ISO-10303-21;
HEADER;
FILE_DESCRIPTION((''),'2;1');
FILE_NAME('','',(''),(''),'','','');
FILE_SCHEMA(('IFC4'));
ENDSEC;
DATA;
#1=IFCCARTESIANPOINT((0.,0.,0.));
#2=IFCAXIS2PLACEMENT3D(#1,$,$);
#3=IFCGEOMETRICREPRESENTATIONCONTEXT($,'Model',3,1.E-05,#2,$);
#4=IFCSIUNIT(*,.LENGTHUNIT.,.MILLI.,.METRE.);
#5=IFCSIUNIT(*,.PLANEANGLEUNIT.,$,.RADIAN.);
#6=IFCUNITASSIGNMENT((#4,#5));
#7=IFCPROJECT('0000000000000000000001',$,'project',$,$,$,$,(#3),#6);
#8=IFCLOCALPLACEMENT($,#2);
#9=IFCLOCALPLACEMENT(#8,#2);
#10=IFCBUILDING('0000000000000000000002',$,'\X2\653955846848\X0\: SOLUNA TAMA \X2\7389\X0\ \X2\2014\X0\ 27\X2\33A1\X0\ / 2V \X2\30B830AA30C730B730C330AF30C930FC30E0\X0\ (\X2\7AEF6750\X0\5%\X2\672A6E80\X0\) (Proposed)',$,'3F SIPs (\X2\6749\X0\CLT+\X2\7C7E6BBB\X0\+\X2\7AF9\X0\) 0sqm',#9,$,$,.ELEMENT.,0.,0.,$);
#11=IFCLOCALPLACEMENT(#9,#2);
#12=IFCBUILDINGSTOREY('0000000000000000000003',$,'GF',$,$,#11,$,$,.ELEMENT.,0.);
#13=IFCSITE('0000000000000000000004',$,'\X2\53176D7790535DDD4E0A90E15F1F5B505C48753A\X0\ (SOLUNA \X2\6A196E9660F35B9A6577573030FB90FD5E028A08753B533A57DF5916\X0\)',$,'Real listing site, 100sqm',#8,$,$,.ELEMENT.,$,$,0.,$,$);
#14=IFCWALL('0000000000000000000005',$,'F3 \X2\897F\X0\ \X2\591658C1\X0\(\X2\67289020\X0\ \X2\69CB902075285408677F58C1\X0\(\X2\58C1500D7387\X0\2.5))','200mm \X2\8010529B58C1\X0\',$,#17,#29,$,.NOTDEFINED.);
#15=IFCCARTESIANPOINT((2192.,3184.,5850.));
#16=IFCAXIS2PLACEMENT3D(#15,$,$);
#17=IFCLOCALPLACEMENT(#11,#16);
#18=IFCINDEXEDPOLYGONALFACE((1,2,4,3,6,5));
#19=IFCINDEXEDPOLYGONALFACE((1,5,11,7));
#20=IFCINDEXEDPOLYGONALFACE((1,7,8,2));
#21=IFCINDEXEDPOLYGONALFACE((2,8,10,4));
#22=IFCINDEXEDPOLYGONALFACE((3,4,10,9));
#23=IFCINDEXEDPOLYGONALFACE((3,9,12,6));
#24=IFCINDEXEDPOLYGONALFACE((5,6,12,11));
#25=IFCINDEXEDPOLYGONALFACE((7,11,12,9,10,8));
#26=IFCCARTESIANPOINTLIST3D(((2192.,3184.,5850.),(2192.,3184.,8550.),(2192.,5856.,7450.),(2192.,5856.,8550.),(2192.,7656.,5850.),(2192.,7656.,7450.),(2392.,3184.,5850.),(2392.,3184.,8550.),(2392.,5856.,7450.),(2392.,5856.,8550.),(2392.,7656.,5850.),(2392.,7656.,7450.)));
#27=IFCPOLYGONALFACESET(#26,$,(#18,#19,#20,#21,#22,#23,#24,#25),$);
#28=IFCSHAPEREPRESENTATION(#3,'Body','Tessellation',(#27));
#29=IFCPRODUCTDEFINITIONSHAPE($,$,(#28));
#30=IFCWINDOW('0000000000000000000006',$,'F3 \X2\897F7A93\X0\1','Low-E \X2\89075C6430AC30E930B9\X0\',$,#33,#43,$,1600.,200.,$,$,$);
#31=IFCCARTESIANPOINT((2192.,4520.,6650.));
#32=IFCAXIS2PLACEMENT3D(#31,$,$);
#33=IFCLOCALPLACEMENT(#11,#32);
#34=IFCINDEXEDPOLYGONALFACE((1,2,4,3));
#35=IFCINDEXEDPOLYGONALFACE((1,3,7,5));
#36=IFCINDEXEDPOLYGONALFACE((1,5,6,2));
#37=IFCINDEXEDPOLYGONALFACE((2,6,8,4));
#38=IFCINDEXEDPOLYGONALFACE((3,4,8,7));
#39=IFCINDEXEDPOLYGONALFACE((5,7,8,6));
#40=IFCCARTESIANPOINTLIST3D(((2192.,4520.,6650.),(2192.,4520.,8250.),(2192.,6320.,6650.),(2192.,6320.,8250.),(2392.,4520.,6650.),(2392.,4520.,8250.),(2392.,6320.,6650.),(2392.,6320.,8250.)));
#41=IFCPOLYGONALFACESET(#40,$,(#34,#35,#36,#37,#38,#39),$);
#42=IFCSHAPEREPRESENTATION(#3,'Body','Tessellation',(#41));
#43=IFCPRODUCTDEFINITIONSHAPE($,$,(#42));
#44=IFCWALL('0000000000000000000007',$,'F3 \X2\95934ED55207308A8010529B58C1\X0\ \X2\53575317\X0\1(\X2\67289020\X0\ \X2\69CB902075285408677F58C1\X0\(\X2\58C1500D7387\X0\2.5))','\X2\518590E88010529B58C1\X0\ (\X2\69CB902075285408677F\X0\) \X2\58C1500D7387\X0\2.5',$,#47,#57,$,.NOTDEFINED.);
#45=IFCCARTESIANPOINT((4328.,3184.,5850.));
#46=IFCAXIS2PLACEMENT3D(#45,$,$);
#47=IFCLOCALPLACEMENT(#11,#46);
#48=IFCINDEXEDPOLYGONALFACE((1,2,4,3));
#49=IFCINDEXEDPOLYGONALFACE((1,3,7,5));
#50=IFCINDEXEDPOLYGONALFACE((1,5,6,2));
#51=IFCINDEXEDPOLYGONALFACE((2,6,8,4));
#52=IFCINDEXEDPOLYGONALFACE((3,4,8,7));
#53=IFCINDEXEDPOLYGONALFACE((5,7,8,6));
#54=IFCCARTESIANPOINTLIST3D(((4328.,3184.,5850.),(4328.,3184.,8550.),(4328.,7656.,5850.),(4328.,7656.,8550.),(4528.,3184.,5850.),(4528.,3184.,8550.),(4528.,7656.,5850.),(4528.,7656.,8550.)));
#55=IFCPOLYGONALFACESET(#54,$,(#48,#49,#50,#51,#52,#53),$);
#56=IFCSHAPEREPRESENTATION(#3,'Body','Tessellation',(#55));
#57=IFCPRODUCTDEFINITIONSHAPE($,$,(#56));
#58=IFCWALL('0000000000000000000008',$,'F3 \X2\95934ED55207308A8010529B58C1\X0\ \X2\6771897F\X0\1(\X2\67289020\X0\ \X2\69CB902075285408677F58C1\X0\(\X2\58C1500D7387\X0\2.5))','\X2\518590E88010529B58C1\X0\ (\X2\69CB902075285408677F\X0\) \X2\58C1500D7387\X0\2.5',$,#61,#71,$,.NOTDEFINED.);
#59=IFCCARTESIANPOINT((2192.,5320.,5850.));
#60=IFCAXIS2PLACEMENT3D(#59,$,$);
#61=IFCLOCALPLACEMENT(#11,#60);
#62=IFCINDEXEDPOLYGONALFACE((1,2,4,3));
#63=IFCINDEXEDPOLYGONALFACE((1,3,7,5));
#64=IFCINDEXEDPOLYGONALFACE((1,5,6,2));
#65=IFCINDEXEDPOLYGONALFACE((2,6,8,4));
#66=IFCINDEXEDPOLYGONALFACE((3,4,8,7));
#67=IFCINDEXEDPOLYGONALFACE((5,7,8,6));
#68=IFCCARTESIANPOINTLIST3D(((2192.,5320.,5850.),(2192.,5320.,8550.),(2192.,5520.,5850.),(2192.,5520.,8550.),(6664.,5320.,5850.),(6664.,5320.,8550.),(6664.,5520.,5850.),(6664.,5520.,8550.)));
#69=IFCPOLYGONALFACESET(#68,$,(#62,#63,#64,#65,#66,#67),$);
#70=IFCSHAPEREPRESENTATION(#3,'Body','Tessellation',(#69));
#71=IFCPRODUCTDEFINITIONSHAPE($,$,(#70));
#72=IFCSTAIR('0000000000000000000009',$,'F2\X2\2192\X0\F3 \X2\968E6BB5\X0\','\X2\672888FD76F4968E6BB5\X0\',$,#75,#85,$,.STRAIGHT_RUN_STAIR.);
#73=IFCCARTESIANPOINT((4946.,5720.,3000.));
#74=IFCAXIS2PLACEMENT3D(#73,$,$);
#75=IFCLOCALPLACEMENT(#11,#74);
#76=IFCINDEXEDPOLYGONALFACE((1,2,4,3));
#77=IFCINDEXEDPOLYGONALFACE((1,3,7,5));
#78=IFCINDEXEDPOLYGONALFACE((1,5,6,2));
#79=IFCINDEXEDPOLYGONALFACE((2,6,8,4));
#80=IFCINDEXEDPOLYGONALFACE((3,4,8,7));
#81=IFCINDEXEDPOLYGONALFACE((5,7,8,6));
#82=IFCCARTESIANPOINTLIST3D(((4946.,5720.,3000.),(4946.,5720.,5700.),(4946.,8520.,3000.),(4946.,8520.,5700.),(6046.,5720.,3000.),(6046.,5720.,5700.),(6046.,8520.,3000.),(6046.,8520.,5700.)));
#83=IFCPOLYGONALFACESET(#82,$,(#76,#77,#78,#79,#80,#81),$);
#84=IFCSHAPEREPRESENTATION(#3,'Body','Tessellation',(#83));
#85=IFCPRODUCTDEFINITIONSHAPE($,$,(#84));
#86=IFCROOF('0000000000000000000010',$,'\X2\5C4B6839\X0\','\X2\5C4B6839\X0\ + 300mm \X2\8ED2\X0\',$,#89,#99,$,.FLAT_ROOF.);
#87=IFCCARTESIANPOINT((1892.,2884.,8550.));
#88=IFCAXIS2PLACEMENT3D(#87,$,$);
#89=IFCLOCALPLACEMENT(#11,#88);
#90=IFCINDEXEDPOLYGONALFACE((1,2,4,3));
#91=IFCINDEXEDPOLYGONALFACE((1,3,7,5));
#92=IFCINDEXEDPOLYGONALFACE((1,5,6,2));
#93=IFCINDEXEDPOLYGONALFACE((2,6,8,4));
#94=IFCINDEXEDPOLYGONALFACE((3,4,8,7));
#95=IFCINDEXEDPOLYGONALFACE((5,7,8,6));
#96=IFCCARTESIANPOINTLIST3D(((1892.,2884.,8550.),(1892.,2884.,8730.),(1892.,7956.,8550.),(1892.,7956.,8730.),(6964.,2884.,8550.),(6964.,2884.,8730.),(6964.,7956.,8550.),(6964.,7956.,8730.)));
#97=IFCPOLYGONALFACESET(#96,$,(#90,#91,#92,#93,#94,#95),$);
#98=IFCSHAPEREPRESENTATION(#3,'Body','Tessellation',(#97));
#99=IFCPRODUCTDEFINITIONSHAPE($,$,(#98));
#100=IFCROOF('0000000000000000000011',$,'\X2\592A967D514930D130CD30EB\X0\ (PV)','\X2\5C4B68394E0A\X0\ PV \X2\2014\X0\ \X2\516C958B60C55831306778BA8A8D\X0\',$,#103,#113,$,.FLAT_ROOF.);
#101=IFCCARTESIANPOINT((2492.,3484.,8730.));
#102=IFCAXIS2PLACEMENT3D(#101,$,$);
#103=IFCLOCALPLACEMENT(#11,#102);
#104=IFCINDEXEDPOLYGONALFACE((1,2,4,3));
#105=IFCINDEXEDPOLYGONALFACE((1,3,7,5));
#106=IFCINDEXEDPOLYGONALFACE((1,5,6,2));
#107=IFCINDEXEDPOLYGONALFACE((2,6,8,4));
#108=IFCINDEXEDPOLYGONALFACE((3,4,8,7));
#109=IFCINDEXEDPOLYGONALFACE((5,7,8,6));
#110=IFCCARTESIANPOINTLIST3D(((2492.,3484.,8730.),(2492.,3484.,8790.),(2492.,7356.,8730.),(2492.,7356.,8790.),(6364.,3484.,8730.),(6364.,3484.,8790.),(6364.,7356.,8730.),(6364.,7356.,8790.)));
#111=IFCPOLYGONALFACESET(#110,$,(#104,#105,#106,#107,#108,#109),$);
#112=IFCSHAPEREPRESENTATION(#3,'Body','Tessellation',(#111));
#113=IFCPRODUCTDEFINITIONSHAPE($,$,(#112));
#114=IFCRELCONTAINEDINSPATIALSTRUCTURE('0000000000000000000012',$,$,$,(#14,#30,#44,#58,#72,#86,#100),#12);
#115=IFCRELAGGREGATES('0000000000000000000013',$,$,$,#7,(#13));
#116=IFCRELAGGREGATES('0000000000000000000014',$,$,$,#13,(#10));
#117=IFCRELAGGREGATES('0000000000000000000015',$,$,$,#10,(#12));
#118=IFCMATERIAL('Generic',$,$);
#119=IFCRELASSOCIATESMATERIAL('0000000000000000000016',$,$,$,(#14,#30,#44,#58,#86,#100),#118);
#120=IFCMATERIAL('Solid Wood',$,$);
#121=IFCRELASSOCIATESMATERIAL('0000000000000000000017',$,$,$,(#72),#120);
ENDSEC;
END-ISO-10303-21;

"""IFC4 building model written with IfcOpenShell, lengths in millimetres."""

from ifc_helpers import new_model, si_unit, frame, frame_2d, origin, place, context, project, spatial, rectangle, extrude, material, element, fill, save


model = new_model("IFC4")

# Units and contexts
model_context = context("Model", 3, precision=1e-05, world=origin())
ifc_project = project(units=[si_unit("LENGTHUNIT", "METRE", prefix="MILLI"), si_unit("PLANEANGLEUNIT", "RADIAN")], contexts=[model_context])

# Site, building, storey
site_placement = place(None, origin())
site = spatial("IfcSite", under=ifc_project, at=site_placement, Name="北海道川上郡弟子屈町 (SOLUNA 標準想定敷地・都市計画区域外)", ObjectType="Real listing site, 100sqm", CompositionType="ELEMENT", RefElevation=0.0)
building_placement = place(site_placement, origin())
building = spatial("IfcBuilding", under=site, at=building_placement, Name="改善案: SOLUNA TAMA 玉 — 27㎡ / 2V ジオデシックドーム (端材5%未満) (Proposed)", ObjectType="3F SIPs (杉CLT+籾殻+竹) 0sqm", CompositionType="ELEMENT", ElevationOfRefHeight=0.0, ElevationOfTerrain=0.0)
storey_placement = place(building_placement, origin())
storey = spatial("IfcBuildingStorey", under=building, at=storey_placement, Name="GF", CompositionType="ELEMENT", Elevation=0.0)

# Shared definitions
ifc_material_1 = material(Name="Generic")

# Wall, opening, window
wall_1_placement = place(storey_placement, frame((2192.0, 3184.0, 5850.0)))
wall_1 = element("IfcWall", 1, at=wall_1_placement, inside=storey, material=ifc_material_1, Name="F3 西 外壁(木造 構造用合板壁(壁倍率2.5))", Description="200mm 耐力壁", PredefinedType="NOTDEFINED", context=model_context, shape_type="SweptSolid", body=[
    extrude(rectangle(XDim=200.0, YDim=4472.0, at=frame_2d((100.0, 2236.0))), frame((2192.0, 3184.0, 5850.0)), (0.0, 0.0, 1.0), 2700.0),
])
opening_1_placement = place(storey_placement, frame((2192.0, 4520.0, 6650.0)))
opening_1 = element("IfcOpeningElement", 2, at=opening_1_placement, cuts=wall_1, PredefinedType="NOTDEFINED", context=model_context, shape_type="SweptSolid", body=[
    extrude(rectangle(XDim=200.0, YDim=1800.0, at=frame_2d((100.0, 900.0))), frame((2192.0, 4520.0, 6650.0)), (0.0, 0.0, 1.0), 1600.0),
])
window_1_placement = place(storey_placement, frame((2192.0, 4520.0, 6650.0)))
window_1 = element("IfcWindow", 3, at=window_1_placement, inside=storey, material=ifc_material_1, Name="F3 西窓1", Description="Low-E 複層ガラス", OverallHeight=1600.0, OverallWidth=200.0, context=model_context, shape_type="SweptSolid", body=[
    extrude(rectangle(XDim=200.0, YDim=1800.0, at=frame_2d((100.0, 900.0))), frame((2192.0, 4520.0, 6650.0)), (0.0, 0.0, 1.0), 1600.0),
])
fill(opening_1, window_1)

# Walls
wall_2_placement = place(storey_placement, frame((4328.0, 3184.0, 5850.0)))
element("IfcWall", 4, at=wall_2_placement, inside=storey, material=ifc_material_1, Name="F3 間仕切り耐力壁 南北1(木造 構造用合板壁(壁倍率2.5))", Description="内部耐力壁 (構造用合板) 壁倍率2.5", PredefinedType="NOTDEFINED", context=model_context, shape_type="SweptSolid", body=[
    extrude(rectangle(XDim=200.0, YDim=4472.0, at=frame_2d((100.0, 2236.0))), frame((4328.0, 3184.0, 5850.0)), (0.0, 0.0, 1.0), 2700.0),
])
wall_3_placement = place(storey_placement, frame((2192.0, 5320.0, 5850.0)))
element("IfcWall", 5, at=wall_3_placement, inside=storey, material=ifc_material_1, Name="F3 間仕切り耐力壁 東西1(木造 構造用合板壁(壁倍率2.5))", Description="内部耐力壁 (構造用合板) 壁倍率2.5", PredefinedType="NOTDEFINED", context=model_context, shape_type="SweptSolid", body=[
    extrude(rectangle(XDim=4472.0, YDim=200.0, at=frame_2d((2236.0, 100.0))), frame((2192.0, 5320.0, 5850.0)), (0.0, 0.0, 1.0), 2700.0),
])

# Stair
ifc_material_2 = material(Name="Solid Wood")
stair_placement = place(storey_placement, frame((4946.0, 5720.0, 3000.0)))
element("IfcStair", 6, at=stair_placement, inside=storey, material=ifc_material_2, Name="F2→F3 階段", Description="木製直階段", PredefinedType="STRAIGHT_RUN_STAIR", context=model_context, shape_type="SweptSolid", body=[
    extrude(rectangle(XDim=1100.0, YDim=2800.0, at=frame_2d((550.0, 1400.0))), frame((4946.0, 5720.0, 3000.0)), (0.0, 0.0, 1.0), 2700.0),
])

# Roofs
roof_1_placement = place(storey_placement, frame((1892.0, 2884.0, 8550.0)))
element("IfcRoof", 7, at=roof_1_placement, inside=storey, material=ifc_material_1, Name="屋根", Description="屋根 + 300mm 軒", PredefinedType="FLAT_ROOF", context=model_context, shape_type="SweptSolid", body=[
    extrude(rectangle(XDim=5072.0, YDim=5072.0, at=frame_2d((2536.0, 2536.0))), frame((1892.0, 2884.0, 8550.0)), (0.0, 0.0, 1.0), 180.0),
])
roof_2_placement = place(storey_placement, frame((2492.0, 3484.0, 8730.0)))
element("IfcRoof", 8, at=roof_2_placement, inside=storey, material=ifc_material_1, Name="太陽光パネル (PV)", Description="屋根上 PV — 公開情報で確認", PredefinedType="FLAT_ROOF", context=model_context, shape_type="SweptSolid", body=[
    extrude(rectangle(XDim=3872.0, YDim=3872.0, at=frame_2d((1936.0, 1936.0))), frame((2492.0, 3484.0, 8730.0)), (0.0, 0.0, 1.0), 60.0),
])

save(model, "model.ifc")
